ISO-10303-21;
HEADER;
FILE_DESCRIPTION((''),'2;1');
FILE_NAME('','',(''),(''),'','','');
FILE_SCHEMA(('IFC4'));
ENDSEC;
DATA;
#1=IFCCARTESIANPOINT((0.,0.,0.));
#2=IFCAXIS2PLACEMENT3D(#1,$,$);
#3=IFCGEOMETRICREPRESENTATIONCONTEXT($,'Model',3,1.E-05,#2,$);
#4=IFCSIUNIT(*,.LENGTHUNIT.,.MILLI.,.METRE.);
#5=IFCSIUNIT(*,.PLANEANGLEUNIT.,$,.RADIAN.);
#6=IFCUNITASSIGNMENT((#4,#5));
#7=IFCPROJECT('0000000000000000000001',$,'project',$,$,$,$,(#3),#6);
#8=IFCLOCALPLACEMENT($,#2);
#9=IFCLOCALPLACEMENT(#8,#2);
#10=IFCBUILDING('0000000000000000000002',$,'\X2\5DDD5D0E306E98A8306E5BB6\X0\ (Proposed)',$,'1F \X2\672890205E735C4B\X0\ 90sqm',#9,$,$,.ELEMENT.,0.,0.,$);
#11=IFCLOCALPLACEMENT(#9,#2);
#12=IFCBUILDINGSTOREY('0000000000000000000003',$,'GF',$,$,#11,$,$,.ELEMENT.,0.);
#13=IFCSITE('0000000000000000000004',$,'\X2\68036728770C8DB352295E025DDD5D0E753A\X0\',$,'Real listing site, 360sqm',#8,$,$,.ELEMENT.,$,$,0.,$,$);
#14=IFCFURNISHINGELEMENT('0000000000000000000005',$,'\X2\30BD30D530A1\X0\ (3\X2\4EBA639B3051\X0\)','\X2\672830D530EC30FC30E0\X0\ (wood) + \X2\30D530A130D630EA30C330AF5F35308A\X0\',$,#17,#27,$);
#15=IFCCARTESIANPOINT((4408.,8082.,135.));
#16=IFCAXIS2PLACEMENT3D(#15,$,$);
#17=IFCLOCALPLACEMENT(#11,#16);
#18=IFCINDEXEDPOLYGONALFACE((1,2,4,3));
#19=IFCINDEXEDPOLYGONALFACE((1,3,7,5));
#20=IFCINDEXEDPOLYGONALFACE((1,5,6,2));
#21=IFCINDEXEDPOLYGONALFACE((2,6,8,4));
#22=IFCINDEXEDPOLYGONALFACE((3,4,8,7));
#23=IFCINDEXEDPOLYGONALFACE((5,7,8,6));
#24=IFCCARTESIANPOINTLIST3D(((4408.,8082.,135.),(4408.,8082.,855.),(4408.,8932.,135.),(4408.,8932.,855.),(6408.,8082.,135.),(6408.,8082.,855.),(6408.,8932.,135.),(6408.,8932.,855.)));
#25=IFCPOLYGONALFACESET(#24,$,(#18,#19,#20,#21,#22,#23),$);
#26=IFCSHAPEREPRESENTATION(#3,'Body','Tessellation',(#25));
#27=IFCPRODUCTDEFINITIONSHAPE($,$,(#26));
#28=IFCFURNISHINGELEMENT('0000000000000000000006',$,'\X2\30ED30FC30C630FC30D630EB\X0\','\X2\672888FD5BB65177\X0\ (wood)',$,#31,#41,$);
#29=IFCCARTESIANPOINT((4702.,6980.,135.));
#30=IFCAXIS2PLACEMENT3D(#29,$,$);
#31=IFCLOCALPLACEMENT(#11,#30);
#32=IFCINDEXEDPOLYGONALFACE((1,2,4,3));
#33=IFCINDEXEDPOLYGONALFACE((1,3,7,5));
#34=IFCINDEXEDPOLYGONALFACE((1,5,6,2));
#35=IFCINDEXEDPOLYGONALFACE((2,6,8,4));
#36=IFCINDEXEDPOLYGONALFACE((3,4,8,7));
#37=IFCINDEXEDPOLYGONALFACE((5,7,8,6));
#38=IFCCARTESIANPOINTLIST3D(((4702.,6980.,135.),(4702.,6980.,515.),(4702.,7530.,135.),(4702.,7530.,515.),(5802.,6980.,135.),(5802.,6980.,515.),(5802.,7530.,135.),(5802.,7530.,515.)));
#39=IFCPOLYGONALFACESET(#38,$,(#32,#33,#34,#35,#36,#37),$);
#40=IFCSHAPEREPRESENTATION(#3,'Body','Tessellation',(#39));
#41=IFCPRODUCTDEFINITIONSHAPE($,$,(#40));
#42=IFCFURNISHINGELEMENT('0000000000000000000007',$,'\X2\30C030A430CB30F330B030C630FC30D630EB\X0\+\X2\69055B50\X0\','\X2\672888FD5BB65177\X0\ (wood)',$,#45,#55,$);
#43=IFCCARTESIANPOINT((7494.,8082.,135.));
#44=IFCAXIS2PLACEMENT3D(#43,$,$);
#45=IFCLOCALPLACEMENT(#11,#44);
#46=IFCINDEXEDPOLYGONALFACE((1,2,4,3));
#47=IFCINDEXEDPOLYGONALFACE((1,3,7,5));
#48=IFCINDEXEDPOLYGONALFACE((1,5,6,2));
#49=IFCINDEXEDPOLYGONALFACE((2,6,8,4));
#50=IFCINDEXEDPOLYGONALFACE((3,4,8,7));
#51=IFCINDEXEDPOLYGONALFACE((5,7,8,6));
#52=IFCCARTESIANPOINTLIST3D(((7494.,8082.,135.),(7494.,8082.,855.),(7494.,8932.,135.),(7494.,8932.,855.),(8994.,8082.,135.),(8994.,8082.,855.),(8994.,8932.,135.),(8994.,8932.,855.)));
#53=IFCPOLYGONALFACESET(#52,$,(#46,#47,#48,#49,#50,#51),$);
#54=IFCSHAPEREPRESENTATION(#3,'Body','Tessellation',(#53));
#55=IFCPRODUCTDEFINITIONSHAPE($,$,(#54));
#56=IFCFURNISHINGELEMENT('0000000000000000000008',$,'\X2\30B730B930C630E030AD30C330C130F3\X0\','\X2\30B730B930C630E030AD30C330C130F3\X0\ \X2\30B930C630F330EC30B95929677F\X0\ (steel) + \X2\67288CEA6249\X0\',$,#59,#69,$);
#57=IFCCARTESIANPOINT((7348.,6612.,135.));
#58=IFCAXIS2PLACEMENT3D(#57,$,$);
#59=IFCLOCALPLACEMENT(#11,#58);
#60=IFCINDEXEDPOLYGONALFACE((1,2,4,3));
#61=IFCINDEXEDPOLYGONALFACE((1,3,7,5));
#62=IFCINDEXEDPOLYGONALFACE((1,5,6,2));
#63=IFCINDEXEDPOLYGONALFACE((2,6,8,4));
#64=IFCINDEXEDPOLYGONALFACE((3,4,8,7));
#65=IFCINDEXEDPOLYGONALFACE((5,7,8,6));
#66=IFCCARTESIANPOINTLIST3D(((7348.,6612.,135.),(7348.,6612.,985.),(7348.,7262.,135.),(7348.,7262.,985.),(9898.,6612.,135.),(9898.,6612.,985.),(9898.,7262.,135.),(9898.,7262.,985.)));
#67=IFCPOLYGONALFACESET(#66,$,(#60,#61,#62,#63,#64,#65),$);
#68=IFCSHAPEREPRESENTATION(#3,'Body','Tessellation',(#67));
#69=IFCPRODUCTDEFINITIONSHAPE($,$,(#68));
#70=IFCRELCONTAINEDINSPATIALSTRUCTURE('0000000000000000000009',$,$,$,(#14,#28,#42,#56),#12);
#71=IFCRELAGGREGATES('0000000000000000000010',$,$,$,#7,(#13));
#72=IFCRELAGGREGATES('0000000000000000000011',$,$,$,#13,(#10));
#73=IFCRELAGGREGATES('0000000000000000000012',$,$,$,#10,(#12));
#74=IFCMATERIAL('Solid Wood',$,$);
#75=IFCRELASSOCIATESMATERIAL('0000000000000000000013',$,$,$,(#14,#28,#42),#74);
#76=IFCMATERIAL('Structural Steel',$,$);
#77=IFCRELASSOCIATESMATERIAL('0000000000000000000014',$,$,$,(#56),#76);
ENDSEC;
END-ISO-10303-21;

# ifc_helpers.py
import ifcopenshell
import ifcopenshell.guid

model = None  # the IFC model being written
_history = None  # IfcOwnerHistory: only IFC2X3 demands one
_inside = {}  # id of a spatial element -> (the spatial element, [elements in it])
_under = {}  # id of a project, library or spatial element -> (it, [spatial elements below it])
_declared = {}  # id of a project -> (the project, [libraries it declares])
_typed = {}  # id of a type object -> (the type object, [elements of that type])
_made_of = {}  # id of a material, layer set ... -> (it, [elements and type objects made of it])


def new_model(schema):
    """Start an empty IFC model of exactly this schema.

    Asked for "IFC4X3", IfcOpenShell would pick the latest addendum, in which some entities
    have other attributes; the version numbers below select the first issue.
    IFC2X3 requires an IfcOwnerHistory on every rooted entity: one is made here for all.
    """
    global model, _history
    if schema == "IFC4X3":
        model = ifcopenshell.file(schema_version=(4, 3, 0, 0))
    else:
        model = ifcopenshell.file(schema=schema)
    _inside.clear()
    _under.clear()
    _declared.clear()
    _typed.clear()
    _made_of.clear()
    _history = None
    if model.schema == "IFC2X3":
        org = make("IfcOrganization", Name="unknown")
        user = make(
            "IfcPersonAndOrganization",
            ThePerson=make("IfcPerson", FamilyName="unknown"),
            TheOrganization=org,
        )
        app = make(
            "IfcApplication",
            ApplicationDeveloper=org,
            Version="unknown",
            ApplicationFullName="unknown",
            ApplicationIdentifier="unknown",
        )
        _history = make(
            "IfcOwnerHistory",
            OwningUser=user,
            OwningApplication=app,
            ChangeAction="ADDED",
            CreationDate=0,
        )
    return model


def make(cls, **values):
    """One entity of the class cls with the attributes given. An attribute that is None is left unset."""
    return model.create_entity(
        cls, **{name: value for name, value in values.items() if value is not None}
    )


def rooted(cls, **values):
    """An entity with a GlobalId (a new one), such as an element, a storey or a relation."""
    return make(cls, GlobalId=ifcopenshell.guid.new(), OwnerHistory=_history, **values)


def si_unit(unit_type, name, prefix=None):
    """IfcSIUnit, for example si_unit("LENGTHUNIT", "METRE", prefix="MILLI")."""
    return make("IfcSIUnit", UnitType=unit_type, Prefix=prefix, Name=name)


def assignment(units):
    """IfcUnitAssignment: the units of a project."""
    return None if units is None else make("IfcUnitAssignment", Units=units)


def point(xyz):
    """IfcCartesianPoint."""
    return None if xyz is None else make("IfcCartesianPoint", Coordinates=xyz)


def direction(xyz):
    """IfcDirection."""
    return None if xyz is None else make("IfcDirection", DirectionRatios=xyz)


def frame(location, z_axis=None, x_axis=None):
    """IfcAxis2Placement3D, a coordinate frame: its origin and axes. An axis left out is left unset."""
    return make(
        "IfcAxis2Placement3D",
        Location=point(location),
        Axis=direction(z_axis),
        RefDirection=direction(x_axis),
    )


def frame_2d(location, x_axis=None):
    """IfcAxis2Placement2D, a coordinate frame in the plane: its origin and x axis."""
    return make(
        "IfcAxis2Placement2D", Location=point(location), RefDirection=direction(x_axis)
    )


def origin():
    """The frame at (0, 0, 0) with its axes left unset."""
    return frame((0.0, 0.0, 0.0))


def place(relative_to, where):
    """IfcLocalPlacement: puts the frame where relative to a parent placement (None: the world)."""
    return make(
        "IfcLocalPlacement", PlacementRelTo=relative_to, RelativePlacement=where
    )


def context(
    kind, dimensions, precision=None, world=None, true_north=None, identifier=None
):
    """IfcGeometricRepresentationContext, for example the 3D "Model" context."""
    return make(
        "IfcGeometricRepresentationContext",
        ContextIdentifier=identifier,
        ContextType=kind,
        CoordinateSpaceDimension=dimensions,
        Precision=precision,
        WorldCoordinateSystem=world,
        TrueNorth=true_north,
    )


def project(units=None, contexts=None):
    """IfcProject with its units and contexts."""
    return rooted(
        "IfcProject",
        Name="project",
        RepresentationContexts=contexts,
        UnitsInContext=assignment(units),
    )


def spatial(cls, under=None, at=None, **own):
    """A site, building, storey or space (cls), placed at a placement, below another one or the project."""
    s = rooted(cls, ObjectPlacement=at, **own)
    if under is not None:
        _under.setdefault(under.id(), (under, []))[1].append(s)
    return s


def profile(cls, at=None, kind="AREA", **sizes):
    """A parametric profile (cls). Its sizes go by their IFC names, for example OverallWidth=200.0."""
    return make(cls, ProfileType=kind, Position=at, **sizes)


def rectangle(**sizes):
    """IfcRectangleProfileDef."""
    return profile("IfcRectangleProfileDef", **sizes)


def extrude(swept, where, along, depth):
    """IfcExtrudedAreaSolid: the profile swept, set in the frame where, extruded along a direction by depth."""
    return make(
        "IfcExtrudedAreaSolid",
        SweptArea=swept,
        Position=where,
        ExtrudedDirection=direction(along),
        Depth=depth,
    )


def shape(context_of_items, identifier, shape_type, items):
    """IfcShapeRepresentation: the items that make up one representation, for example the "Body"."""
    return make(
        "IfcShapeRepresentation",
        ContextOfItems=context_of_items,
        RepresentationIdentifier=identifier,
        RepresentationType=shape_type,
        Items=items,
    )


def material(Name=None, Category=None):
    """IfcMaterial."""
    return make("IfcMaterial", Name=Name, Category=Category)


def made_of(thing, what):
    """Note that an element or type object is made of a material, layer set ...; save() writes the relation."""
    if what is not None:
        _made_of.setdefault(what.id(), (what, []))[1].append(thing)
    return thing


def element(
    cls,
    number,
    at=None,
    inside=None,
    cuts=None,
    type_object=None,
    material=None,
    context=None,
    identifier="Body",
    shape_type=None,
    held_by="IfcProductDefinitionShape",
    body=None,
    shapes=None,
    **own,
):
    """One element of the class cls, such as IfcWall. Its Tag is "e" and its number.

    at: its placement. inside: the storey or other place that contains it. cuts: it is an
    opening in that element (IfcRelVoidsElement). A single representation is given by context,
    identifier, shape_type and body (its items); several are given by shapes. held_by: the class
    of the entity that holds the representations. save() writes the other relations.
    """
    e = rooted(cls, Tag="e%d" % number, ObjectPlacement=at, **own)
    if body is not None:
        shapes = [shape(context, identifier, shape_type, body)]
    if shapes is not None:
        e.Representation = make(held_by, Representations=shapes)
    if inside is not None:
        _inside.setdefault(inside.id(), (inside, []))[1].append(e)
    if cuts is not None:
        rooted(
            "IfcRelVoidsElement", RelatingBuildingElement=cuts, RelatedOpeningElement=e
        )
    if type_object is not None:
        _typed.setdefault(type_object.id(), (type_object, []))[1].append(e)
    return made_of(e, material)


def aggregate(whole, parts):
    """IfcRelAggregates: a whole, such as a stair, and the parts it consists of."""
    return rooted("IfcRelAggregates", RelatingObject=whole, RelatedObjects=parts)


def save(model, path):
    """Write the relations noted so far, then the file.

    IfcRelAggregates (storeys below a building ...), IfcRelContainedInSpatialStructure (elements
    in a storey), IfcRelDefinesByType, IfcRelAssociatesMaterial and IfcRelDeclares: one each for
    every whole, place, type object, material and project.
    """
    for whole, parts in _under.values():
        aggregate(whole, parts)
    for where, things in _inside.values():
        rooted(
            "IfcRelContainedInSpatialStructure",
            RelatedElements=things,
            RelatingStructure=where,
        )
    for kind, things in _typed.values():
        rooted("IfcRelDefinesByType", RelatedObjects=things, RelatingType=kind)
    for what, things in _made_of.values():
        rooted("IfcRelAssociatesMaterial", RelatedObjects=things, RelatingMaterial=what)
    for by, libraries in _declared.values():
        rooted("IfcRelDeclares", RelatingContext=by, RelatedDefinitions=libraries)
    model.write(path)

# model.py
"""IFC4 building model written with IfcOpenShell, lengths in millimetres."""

from ifc_helpers import new_model, si_unit, frame, frame_2d, origin, place, context, project, spatial, rectangle, extrude, material, element, save


model = new_model("IFC4")

# Units and contexts
model_context = context("Model", 3, precision=1e-05, world=origin())
ifc_project = project(units=[si_unit("LENGTHUNIT", "METRE", prefix="MILLI"), si_unit("PLANEANGLEUNIT", "RADIAN")], contexts=[model_context])

# Site, building, storey
site_placement = place(None, origin())
site = spatial("IfcSite", under=ifc_project, at=site_placement, Name="栃木県足利市川崎町", ObjectType="Real listing site, 360sqm", CompositionType="ELEMENT", RefElevation=0.0)
building_placement = place(site_placement, origin())
building = spatial("IfcBuilding", under=site, at=building_placement, Name="川崎の風の家 (Proposed)", ObjectType="1F 木造平屋 90sqm", CompositionType="ELEMENT", ElevationOfRefHeight=0.0, ElevationOfTerrain=0.0)
storey_placement = place(building_placement, origin())
storey = spatial("IfcBuildingStorey", under=building, at=storey_placement, Name="GF", CompositionType="ELEMENT", Elevation=0.0)

# Shared definitions
ifc_material_1 = material(Name="Solid Wood")

# Shared definitions
ifc_material_2 = material(Name="Structural Steel")

# Furnishing elements
furnishing_1_placement = place(storey_placement, frame((4408.0, 8082.0, 135.0)))
element("IfcFurnishingElement", 1, at=furnishing_1_placement, inside=storey, material=ifc_material_1, Name="ソファ (3人掛け)", Description="木フレーム (wood) + ファブリック張り", context=model_context, shape_type="SweptSolid", body=[
    extrude(rectangle(XDim=2000.0, YDim=850.0, at=frame_2d((1000.0, 425.0))), frame((4408.0, 8082.0, 135.0)), (0.0, 0.0, 1.0), 720.0),
])
furnishing_2_placement = place(storey_placement, frame((4702.0, 6980.0, 135.0)))
element("IfcFurnishingElement", 2, at=furnishing_2_placement, inside=storey, material=ifc_material_1, Name="ローテーブル", Description="木製家具 (wood)", context=model_context, shape_type="SweptSolid", body=[
    extrude(rectangle(XDim=1100.0, YDim=550.0, at=frame_2d((550.0, 275.0))), frame((4702.0, 6980.0, 135.0)), (0.0, 0.0, 1.0), 380.0),
])
furnishing_3_placement = place(storey_placement, frame((7494.0, 8082.0, 135.0)))
element("IfcFurnishingElement", 3, at=furnishing_3_placement, inside=storey, material=ifc_material_1, Name="ダイニングテーブル+椅子", Description="木製家具 (wood)", context=model_context, shape_type="SweptSolid", body=[
    extrude(rectangle(XDim=1500.0, YDim=850.0, at=frame_2d((750.0, 425.0))), frame((7494.0, 8082.0, 135.0)), (0.0, 0.0, 1.0), 720.0),
])
furnishing_4_placement = place(storey_placement, frame((7348.0, 6612.0, 135.0)))
element("IfcFurnishingElement", 4, at=furnishing_4_placement, inside=storey, material=ifc_material_2, Name="システムキッチン", Description="システムキッチン ステンレス天板 (steel) + 木質扉", context=model_context, shape_type="SweptSolid", body=[
    extrude(rectangle(XDim=2550.0, YDim=650.0, at=frame_2d((1275.0, 325.0))), frame((7348.0, 6612.0, 135.0)), (0.0, 0.0, 1.0), 850.0),
])

save(model, "model.ifc")
